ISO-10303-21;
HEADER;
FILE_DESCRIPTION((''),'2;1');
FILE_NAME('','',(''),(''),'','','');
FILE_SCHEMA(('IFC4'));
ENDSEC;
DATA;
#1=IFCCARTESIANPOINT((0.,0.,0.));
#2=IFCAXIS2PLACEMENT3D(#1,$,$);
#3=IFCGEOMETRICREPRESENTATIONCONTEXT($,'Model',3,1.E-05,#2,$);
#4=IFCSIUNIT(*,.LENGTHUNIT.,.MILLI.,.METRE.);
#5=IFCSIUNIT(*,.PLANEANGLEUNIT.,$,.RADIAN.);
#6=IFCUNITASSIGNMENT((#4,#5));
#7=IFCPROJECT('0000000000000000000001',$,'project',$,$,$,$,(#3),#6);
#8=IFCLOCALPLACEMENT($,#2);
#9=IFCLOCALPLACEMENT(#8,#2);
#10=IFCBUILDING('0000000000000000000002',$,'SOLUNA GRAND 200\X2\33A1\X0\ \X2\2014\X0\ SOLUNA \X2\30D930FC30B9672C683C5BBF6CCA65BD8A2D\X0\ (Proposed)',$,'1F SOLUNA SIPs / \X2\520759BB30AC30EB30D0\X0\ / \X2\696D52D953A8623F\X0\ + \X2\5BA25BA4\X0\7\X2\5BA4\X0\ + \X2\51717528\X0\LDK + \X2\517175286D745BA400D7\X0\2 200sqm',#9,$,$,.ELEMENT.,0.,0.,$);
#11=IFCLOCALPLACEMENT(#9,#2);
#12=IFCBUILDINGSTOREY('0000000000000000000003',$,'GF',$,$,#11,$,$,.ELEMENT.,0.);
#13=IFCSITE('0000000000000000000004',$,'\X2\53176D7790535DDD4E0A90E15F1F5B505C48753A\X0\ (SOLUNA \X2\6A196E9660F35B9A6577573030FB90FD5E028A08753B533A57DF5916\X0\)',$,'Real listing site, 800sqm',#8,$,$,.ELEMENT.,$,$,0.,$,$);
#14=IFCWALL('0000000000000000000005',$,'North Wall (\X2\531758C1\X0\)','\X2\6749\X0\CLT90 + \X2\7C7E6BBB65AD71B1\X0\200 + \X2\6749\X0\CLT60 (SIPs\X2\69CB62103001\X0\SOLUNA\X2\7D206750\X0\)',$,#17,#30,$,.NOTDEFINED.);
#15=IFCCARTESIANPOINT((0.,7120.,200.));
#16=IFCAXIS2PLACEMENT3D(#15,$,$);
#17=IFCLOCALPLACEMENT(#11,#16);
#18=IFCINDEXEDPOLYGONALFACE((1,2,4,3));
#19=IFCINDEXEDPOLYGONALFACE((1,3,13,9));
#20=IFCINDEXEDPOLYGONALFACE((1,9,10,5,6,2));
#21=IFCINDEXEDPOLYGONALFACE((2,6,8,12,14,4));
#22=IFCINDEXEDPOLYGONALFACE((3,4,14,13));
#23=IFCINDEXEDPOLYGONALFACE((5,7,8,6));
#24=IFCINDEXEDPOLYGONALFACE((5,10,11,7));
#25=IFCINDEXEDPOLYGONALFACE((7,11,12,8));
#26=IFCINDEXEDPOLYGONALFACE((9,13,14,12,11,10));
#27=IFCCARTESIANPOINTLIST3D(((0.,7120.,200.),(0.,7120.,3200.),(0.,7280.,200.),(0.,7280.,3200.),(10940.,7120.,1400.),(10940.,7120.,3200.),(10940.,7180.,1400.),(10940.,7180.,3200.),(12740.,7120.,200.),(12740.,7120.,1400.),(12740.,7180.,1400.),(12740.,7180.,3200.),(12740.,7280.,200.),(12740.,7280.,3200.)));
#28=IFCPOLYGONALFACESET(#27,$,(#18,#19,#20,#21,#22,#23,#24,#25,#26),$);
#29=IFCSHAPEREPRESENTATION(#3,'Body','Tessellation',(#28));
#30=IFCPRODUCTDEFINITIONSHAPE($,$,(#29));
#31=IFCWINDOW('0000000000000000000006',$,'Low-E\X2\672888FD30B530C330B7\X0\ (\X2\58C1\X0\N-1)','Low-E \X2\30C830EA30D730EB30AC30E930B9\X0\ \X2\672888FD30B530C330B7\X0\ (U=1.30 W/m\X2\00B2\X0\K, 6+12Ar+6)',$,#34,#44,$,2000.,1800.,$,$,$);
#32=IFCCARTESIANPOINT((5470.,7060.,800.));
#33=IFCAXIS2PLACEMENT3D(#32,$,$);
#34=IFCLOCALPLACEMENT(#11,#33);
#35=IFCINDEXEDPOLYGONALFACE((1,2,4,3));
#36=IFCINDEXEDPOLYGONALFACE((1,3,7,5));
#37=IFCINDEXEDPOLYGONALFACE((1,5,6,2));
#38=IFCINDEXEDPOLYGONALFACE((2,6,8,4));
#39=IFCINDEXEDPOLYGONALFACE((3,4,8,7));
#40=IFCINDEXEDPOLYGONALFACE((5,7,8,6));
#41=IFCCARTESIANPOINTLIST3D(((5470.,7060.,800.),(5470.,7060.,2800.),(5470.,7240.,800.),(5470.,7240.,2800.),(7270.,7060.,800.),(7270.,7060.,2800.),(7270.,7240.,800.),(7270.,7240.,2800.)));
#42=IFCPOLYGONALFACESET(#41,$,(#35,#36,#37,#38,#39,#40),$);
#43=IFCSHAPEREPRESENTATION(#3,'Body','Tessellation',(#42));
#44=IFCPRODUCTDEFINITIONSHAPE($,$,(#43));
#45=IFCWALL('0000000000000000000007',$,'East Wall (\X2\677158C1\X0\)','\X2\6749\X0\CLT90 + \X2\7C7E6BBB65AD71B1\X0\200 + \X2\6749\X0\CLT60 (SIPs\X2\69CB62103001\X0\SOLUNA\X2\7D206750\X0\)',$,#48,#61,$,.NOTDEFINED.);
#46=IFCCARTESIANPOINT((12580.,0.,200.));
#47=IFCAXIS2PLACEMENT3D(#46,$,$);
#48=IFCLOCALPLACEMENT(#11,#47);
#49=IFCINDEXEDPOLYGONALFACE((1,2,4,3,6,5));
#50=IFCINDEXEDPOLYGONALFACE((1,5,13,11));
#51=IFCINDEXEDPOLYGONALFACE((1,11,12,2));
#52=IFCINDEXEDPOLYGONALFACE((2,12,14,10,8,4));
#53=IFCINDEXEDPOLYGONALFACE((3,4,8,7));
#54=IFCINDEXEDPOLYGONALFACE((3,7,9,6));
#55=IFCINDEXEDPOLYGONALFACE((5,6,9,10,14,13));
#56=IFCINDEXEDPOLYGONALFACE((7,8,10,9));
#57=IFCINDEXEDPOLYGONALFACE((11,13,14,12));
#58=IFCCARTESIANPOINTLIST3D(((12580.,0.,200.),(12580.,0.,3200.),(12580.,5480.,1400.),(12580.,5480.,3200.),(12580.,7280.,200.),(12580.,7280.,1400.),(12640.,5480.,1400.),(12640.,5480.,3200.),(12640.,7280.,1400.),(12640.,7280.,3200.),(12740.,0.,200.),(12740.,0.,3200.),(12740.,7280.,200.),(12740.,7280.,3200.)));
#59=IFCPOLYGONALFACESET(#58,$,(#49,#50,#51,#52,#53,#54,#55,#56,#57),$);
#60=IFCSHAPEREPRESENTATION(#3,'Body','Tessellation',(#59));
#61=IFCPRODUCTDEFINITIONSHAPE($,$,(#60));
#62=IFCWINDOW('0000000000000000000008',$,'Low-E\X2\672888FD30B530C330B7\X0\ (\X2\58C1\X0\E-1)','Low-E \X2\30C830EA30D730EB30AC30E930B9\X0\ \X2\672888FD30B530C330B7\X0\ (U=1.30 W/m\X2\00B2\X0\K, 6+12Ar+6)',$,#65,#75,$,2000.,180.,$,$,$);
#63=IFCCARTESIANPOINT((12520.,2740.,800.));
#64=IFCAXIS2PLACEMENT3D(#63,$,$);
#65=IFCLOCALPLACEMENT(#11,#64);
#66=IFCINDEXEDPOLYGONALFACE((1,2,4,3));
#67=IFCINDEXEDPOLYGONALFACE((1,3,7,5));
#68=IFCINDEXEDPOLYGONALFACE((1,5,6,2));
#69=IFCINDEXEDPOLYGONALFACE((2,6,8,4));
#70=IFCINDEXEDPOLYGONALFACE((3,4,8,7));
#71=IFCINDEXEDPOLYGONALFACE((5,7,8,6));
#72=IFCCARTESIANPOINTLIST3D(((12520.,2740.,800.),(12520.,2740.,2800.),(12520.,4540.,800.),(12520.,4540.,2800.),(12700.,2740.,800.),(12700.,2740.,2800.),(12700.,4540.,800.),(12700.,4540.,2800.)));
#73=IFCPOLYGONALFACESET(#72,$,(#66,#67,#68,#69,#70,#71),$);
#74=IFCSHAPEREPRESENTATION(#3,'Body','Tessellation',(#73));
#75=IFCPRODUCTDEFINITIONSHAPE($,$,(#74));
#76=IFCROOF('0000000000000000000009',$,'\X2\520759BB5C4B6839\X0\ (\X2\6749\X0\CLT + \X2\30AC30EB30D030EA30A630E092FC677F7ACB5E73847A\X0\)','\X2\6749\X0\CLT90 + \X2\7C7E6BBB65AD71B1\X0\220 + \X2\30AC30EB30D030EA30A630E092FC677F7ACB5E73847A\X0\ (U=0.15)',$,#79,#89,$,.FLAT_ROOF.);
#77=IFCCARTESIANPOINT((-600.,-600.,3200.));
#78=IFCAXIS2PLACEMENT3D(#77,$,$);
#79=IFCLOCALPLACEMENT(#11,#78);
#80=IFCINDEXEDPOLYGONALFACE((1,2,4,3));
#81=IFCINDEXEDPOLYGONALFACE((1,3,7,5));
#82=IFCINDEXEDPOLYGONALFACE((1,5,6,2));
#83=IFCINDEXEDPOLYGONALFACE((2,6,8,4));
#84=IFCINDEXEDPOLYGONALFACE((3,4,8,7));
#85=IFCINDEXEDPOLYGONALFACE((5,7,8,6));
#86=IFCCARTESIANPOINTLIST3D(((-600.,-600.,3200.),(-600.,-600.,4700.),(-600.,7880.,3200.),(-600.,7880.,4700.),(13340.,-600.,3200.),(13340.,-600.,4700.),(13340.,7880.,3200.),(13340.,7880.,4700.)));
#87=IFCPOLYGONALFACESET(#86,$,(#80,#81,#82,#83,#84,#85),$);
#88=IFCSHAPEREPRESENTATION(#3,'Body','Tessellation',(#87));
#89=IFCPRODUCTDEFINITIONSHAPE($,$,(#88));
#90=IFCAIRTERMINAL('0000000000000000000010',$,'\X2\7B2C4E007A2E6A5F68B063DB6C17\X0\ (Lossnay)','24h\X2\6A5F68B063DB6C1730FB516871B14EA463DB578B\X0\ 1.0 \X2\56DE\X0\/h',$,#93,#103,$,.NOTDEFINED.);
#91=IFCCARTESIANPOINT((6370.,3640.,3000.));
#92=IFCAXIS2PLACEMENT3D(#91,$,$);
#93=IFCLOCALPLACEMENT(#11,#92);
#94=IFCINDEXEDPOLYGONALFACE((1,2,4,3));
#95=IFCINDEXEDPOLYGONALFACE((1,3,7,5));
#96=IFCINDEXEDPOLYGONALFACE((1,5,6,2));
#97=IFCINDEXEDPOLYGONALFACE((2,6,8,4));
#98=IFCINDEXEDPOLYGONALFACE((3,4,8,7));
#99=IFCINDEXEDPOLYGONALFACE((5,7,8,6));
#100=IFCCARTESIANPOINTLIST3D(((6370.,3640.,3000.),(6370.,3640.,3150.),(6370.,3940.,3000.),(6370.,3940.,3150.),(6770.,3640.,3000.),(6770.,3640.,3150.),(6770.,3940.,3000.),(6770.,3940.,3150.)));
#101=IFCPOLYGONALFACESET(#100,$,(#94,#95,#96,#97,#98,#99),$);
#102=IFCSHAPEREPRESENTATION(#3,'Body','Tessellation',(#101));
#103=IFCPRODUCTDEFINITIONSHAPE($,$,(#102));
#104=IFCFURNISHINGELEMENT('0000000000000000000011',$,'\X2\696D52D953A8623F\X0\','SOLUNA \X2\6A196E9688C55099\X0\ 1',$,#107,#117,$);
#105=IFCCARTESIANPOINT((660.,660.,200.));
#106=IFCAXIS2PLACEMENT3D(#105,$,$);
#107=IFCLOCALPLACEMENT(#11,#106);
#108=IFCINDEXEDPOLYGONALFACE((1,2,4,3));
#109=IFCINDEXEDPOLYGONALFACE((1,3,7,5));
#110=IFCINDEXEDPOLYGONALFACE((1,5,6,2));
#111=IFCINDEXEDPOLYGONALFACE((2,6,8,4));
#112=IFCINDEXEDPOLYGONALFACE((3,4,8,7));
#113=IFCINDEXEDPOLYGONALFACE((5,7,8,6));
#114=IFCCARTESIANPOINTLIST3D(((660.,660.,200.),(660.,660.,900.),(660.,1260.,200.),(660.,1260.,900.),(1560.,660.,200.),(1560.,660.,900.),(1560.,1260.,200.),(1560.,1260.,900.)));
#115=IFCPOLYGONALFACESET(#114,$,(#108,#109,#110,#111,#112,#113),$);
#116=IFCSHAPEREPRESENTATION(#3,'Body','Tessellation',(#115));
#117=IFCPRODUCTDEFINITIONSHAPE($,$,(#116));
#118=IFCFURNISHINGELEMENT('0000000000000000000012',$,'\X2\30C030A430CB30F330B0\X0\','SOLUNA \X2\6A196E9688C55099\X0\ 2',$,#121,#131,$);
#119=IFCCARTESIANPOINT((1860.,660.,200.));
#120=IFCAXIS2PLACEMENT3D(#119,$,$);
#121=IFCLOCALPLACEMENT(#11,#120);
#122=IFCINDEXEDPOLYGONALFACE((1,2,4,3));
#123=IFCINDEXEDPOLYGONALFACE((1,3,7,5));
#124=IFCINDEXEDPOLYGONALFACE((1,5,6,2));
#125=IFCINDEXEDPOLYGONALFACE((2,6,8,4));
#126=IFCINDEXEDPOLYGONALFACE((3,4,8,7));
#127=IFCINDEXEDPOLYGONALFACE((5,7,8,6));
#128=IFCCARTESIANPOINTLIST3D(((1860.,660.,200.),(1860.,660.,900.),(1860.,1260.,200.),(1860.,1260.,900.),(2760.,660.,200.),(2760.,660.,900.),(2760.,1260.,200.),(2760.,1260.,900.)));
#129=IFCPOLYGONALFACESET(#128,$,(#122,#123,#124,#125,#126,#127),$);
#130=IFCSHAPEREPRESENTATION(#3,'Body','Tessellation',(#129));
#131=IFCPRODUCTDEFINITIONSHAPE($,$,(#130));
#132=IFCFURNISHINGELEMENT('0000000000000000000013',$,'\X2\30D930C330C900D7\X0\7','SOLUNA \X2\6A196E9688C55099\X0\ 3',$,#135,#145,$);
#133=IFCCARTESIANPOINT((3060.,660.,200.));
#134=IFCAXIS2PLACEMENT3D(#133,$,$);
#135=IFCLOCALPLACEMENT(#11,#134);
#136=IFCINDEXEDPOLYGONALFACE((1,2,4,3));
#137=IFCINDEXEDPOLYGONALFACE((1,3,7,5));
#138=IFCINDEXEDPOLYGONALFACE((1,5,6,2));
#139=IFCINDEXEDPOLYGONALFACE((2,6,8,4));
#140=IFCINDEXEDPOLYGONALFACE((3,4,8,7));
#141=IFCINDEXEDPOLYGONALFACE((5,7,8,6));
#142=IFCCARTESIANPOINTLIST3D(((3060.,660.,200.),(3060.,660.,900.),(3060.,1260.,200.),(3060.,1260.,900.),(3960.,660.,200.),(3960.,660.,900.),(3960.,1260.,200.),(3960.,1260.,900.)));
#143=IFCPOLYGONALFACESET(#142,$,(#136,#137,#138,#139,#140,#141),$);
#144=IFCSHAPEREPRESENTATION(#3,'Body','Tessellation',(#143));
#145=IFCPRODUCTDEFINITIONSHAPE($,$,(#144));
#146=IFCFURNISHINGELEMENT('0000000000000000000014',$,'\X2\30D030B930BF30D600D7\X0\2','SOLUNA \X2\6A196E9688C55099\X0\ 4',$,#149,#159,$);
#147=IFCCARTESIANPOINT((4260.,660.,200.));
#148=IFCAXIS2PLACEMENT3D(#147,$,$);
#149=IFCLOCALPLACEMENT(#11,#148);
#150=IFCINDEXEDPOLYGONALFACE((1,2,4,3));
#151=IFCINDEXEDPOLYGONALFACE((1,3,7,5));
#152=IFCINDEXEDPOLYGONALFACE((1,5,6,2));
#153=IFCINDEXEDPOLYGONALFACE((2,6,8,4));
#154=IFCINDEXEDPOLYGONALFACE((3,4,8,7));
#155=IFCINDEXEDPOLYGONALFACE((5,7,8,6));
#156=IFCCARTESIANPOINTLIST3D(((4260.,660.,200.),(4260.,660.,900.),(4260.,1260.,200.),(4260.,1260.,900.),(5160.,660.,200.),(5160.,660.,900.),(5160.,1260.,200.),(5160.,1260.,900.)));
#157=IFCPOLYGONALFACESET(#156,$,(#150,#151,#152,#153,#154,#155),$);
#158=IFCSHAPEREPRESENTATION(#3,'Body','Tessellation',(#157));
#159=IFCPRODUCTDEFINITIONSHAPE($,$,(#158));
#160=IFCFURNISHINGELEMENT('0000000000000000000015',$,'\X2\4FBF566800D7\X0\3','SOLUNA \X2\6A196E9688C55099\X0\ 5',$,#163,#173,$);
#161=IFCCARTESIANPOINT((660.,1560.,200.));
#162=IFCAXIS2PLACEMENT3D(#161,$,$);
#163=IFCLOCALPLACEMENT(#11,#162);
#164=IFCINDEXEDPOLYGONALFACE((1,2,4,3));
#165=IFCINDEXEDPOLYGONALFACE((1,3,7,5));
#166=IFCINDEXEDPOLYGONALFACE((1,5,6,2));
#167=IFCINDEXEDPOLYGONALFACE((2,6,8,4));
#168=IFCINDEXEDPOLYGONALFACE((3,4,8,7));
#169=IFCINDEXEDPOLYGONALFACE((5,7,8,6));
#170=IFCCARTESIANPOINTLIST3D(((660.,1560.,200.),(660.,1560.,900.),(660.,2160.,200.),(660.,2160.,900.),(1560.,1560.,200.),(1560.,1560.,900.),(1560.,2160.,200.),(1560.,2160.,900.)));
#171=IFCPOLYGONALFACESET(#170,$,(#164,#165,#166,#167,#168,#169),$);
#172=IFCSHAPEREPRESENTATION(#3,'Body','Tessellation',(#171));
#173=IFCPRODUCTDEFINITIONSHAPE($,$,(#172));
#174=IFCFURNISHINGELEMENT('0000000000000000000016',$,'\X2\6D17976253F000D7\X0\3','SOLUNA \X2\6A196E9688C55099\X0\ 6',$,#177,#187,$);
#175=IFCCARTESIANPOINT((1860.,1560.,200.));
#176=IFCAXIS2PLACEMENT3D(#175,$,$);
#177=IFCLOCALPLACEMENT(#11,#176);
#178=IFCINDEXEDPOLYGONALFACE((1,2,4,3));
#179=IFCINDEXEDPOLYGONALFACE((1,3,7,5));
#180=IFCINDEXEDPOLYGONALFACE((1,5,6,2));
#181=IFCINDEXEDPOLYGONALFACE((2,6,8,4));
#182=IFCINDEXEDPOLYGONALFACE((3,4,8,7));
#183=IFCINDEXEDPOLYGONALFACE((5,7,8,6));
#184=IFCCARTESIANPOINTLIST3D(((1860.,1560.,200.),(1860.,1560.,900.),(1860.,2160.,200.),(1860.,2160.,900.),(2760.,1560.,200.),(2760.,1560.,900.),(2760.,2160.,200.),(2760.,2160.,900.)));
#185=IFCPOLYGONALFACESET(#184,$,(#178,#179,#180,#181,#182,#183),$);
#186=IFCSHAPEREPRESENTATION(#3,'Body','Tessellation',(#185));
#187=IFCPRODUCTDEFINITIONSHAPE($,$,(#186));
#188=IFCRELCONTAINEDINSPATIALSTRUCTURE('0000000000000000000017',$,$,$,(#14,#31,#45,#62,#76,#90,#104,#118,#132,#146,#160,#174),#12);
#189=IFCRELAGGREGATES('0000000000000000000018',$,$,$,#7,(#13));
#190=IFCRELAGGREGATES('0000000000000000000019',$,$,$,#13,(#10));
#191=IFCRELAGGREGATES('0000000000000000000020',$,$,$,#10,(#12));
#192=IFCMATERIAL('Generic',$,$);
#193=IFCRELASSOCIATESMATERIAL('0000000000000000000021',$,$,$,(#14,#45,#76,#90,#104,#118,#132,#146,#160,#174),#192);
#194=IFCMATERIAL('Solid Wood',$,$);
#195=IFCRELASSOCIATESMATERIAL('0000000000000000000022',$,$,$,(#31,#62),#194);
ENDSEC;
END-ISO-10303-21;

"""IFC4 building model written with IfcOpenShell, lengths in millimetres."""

from ifc_helpers import new_model, si_unit, frame, frame_2d, origin, place, context, project, spatial, rectangle, extrude, material, element, fill, save


model = new_model("IFC4")

# Units and contexts
model_context = context("Model", 3, precision=1e-05, world=origin())
ifc_project = project(units=[si_unit("LENGTHUNIT", "METRE", prefix="MILLI"), si_unit("PLANEANGLEUNIT", "RADIAN")], contexts=[model_context])

# Site, building, storey
site_placement = place(None, origin())
site = spatial("IfcSite", under=ifc_project, at=site_placement, Name="北海道川上郡弟子屈町 (SOLUNA 標準想定敷地・都市計画区域外)", ObjectType="Real listing site, 800sqm", CompositionType="ELEMENT", RefElevation=0.0)
building_placement = place(site_placement, origin())
building = spatial("IfcBuilding", under=site, at=building_placement, Name="SOLUNA GRAND 200㎡ — SOLUNA ベース本格宿泊施設 (Proposed)", ObjectType="1F SOLUNA SIPs / 切妻ガルバ / 業務厨房 + 客室7室 + 共用LDK + 共用浴室×2 200sqm", CompositionType="ELEMENT", ElevationOfRefHeight=0.0, ElevationOfTerrain=0.0)
storey_placement = place(building_placement, origin())
storey = spatial("IfcBuildingStorey", under=building, at=storey_placement, Name="GF", CompositionType="ELEMENT", Elevation=0.0)

# Shared definitions
ifc_material_1 = material(Name="Generic")

# Shared definitions
ifc_material_2 = material(Name="Solid Wood")

# Walls, openings, windows
wall_1_placement = place(storey_placement, frame((0.0, 7120.0, 200.0)))
wall_1 = element("IfcWall", 1, at=wall_1_placement, inside=storey, material=ifc_material_1, Name="North Wall (北壁)", Description="杉CLT90 + 籾殻断熱200 + 杉CLT60 (SIPs構成、SOLUNA素材)", PredefinedType="NOTDEFINED", context=model_context, shape_type="SweptSolid", body=[
    extrude(rectangle(XDim=12740.0, YDim=160.0, at=frame_2d((6370.0, 80.0))), frame((0.0, 7120.0, 200.0)), (0.0, 0.0, 1.0), 3000.0),
])
opening_1_placement = place(storey_placement, frame((5470.0, 7060.0, 800.0)))
opening_1 = element("IfcOpeningElement", 2, at=opening_1_placement, cuts=wall_1, PredefinedType="NOTDEFINED", context=model_context, shape_type="SweptSolid", body=[
    extrude(rectangle(XDim=1800.0, YDim=180.0, at=frame_2d((900.0, 90.0))), frame((5470.0, 7060.0, 800.0)), (0.0, 0.0, 1.0), 2000.0),
])
window_1_placement = place(storey_placement, frame((5470.0, 7060.0, 800.0)))
window_1 = element("IfcWindow", 3, at=window_1_placement, inside=storey, material=ifc_material_2, Name="Low-E木製サッシ (壁N-1)", Description="Low-E トリプルガラス 木製サッシ (U=1.30 W/m²K, 6+12Ar+6)", OverallHeight=2000.0, OverallWidth=1800.0, context=model_context, shape_type="SweptSolid", body=[
    extrude(rectangle(XDim=1800.0, YDim=180.0, at=frame_2d((900.0, 90.0))), frame((5470.0, 7060.0, 800.0)), (0.0, 0.0, 1.0), 2000.0),
])
fill(opening_1, window_1)
wall_2_placement = place(storey_placement, frame((12580.0, 0.0, 200.0)))
wall_2 = element("IfcWall", 4, at=wall_2_placement, inside=storey, material=ifc_material_1, Name="East Wall (東壁)", Description="杉CLT90 + 籾殻断熱200 + 杉CLT60 (SIPs構成、SOLUNA素材)", PredefinedType="NOTDEFINED", context=model_context, shape_type="SweptSolid", body=[
    extrude(rectangle(XDim=160.0, YDim=7280.0, at=frame_2d((80.0, 3640.0))), frame((12580.0, 0.0, 200.0)), (0.0, 0.0, 1.0), 3000.0),
])
opening_2_placement = place(storey_placement, frame((12520.0, 2740.0, 800.0)))
opening_2 = element("IfcOpeningElement", 5, at=opening_2_placement, cuts=wall_2, PredefinedType="NOTDEFINED", context=model_context, shape_type="SweptSolid", body=[
    extrude(rectangle(XDim=180.0, YDim=1800.0, at=frame_2d((90.0, 900.0))), frame((12520.0, 2740.0, 800.0)), (0.0, 0.0, 1.0), 2000.0),
])
window_2_placement = place(storey_placement, frame((12520.0, 2740.0, 800.0)))
window_2 = element("IfcWindow", 6, at=window_2_placement, inside=storey, material=ifc_material_2, Name="Low-E木製サッシ (壁E-1)", Description="Low-E トリプルガラス 木製サッシ (U=1.30 W/m²K, 6+12Ar+6)", OverallHeight=2000.0, OverallWidth=180.0, context=model_context, shape_type="SweptSolid", body=[
    extrude(rectangle(XDim=180.0, YDim=1800.0, at=frame_2d((90.0, 900.0))), frame((12520.0, 2740.0, 800.0)), (0.0, 0.0, 1.0), 2000.0),
])
fill(opening_2, window_2)

# Roof
roof_placement = place(storey_placement, frame((-600.0, -600.0, 3200.0)))
element("IfcRoof", 7, at=roof_placement, inside=storey, material=ifc_material_1, Name="切妻屋根 (杉CLT + ガルバリウム鋼板立平葺)", Description="杉CLT90 + 籾殻断熱220 + ガルバリウム鋼板立平葺 (U=0.15)", PredefinedType="FLAT_ROOF", context=model_context, shape_type="SweptSolid", body=[
    extrude(rectangle(XDim=13940.0, YDim=8480.0, at=frame_2d((6970.0, 4240.0))), frame((-600.0, -600.0, 3200.0)), (0.0, 0.0, 1.0), 1500.0),
])

# Air terminal
air_terminal_placement = place(storey_placement, frame((6370.0, 3640.0, 3000.0)))
element("IfcAirTerminal", 8, at=air_terminal_placement, inside=storey, material=ifc_material_1, Name="第一種機械換気 (Lossnay)", Description="24h機械換気・全熱交換型 1.0 回/h", PredefinedType="NOTDEFINED", context=model_context, shape_type="SweptSolid", body=[
    extrude(rectangle(XDim=400.0, YDim=300.0, at=frame_2d((200.0, 150.0))), frame((6370.0, 3640.0, 3000.0)), (0.0, 0.0, 1.0), 150.0),
])

# Furnishing elements
furnishing_1_placement = place(storey_placement, frame((660.0, 660.0, 200.0)))
element("IfcFurnishingElement", 9, at=furnishing_1_placement, inside=storey, material=ifc_material_1, Name="業務厨房", Description="SOLUNA 標準装備 1", context=model_context, shape_type="SweptSolid", body=[
    extrude(rectangle(XDim=900.0, YDim=600.0, at=frame_2d((450.0, 300.0))), frame((660.0, 660.0, 200.0)), (0.0, 0.0, 1.0), 700.0),
])
furnishing_2_placement = place(storey_placement, frame((1860.0, 660.0, 200.0)))
element("IfcFurnishingElement", 10, at=furnishing_2_placement, inside=storey, material=ifc_material_1, Name="ダイニング", Description="SOLUNA 標準装備 2", context=model_context, shape_type="SweptSolid", body=[
    extrude(rectangle(XDim=900.0, YDim=600.0, at=frame_2d((450.0, 300.0))), frame((1860.0, 660.0, 200.0)), (0.0, 0.0, 1.0), 700.0),
])
furnishing_3_placement = place(storey_placement, frame((3060.0, 660.0, 200.0)))
element("IfcFurnishingElement", 11, at=furnishing_3_placement, inside=storey, material=ifc_material_1, Name="ベッド×7", Description="SOLUNA 標準装備 3", context=model_context, shape_type="SweptSolid", body=[
    extrude(rectangle(XDim=900.0, YDim=600.0, at=frame_2d((450.0, 300.0))), frame((3060.0, 660.0, 200.0)), (0.0, 0.0, 1.0), 700.0),
])
furnishing_4_placement = place(storey_placement, frame((4260.0, 660.0, 200.0)))
element("IfcFurnishingElement", 12, at=furnishing_4_placement, inside=storey, material=ifc_material_1, Name="バスタブ×2", Description="SOLUNA 標準装備 4", context=model_context, shape_type="SweptSolid", body=[
    extrude(rectangle(XDim=900.0, YDim=600.0, at=frame_2d((450.0, 300.0))), frame((4260.0, 660.0, 200.0)), (0.0, 0.0, 1.0), 700.0),
])
furnishing_5_placement = place(storey_placement, frame((660.0, 1560.0, 200.0)))
element("IfcFurnishingElement", 13, at=furnishing_5_placement, inside=storey, material=ifc_material_1, Name="便器×3", Description="SOLUNA 標準装備 5", context=model_context, shape_type="SweptSolid", body=[
    extrude(rectangle(XDim=900.0, YDim=600.0, at=frame_2d((450.0, 300.0))), frame((660.0, 1560.0, 200.0)), (0.0, 0.0, 1.0), 700.0),
])
furnishing_6_placement = place(storey_placement, frame((1860.0, 1560.0, 200.0)))
element("IfcFurnishingElement", 14, at=furnishing_6_placement, inside=storey, material=ifc_material_1, Name="洗面台×3", Description="SOLUNA 標準装備 6", context=model_context, shape_type="SweptSolid", body=[
    extrude(rectangle(XDim=900.0, YDim=600.0, at=frame_2d((450.0, 300.0))), frame((1860.0, 1560.0, 200.0)), (0.0, 0.0, 1.0), 700.0),
])

save(model, "model.ifc")
